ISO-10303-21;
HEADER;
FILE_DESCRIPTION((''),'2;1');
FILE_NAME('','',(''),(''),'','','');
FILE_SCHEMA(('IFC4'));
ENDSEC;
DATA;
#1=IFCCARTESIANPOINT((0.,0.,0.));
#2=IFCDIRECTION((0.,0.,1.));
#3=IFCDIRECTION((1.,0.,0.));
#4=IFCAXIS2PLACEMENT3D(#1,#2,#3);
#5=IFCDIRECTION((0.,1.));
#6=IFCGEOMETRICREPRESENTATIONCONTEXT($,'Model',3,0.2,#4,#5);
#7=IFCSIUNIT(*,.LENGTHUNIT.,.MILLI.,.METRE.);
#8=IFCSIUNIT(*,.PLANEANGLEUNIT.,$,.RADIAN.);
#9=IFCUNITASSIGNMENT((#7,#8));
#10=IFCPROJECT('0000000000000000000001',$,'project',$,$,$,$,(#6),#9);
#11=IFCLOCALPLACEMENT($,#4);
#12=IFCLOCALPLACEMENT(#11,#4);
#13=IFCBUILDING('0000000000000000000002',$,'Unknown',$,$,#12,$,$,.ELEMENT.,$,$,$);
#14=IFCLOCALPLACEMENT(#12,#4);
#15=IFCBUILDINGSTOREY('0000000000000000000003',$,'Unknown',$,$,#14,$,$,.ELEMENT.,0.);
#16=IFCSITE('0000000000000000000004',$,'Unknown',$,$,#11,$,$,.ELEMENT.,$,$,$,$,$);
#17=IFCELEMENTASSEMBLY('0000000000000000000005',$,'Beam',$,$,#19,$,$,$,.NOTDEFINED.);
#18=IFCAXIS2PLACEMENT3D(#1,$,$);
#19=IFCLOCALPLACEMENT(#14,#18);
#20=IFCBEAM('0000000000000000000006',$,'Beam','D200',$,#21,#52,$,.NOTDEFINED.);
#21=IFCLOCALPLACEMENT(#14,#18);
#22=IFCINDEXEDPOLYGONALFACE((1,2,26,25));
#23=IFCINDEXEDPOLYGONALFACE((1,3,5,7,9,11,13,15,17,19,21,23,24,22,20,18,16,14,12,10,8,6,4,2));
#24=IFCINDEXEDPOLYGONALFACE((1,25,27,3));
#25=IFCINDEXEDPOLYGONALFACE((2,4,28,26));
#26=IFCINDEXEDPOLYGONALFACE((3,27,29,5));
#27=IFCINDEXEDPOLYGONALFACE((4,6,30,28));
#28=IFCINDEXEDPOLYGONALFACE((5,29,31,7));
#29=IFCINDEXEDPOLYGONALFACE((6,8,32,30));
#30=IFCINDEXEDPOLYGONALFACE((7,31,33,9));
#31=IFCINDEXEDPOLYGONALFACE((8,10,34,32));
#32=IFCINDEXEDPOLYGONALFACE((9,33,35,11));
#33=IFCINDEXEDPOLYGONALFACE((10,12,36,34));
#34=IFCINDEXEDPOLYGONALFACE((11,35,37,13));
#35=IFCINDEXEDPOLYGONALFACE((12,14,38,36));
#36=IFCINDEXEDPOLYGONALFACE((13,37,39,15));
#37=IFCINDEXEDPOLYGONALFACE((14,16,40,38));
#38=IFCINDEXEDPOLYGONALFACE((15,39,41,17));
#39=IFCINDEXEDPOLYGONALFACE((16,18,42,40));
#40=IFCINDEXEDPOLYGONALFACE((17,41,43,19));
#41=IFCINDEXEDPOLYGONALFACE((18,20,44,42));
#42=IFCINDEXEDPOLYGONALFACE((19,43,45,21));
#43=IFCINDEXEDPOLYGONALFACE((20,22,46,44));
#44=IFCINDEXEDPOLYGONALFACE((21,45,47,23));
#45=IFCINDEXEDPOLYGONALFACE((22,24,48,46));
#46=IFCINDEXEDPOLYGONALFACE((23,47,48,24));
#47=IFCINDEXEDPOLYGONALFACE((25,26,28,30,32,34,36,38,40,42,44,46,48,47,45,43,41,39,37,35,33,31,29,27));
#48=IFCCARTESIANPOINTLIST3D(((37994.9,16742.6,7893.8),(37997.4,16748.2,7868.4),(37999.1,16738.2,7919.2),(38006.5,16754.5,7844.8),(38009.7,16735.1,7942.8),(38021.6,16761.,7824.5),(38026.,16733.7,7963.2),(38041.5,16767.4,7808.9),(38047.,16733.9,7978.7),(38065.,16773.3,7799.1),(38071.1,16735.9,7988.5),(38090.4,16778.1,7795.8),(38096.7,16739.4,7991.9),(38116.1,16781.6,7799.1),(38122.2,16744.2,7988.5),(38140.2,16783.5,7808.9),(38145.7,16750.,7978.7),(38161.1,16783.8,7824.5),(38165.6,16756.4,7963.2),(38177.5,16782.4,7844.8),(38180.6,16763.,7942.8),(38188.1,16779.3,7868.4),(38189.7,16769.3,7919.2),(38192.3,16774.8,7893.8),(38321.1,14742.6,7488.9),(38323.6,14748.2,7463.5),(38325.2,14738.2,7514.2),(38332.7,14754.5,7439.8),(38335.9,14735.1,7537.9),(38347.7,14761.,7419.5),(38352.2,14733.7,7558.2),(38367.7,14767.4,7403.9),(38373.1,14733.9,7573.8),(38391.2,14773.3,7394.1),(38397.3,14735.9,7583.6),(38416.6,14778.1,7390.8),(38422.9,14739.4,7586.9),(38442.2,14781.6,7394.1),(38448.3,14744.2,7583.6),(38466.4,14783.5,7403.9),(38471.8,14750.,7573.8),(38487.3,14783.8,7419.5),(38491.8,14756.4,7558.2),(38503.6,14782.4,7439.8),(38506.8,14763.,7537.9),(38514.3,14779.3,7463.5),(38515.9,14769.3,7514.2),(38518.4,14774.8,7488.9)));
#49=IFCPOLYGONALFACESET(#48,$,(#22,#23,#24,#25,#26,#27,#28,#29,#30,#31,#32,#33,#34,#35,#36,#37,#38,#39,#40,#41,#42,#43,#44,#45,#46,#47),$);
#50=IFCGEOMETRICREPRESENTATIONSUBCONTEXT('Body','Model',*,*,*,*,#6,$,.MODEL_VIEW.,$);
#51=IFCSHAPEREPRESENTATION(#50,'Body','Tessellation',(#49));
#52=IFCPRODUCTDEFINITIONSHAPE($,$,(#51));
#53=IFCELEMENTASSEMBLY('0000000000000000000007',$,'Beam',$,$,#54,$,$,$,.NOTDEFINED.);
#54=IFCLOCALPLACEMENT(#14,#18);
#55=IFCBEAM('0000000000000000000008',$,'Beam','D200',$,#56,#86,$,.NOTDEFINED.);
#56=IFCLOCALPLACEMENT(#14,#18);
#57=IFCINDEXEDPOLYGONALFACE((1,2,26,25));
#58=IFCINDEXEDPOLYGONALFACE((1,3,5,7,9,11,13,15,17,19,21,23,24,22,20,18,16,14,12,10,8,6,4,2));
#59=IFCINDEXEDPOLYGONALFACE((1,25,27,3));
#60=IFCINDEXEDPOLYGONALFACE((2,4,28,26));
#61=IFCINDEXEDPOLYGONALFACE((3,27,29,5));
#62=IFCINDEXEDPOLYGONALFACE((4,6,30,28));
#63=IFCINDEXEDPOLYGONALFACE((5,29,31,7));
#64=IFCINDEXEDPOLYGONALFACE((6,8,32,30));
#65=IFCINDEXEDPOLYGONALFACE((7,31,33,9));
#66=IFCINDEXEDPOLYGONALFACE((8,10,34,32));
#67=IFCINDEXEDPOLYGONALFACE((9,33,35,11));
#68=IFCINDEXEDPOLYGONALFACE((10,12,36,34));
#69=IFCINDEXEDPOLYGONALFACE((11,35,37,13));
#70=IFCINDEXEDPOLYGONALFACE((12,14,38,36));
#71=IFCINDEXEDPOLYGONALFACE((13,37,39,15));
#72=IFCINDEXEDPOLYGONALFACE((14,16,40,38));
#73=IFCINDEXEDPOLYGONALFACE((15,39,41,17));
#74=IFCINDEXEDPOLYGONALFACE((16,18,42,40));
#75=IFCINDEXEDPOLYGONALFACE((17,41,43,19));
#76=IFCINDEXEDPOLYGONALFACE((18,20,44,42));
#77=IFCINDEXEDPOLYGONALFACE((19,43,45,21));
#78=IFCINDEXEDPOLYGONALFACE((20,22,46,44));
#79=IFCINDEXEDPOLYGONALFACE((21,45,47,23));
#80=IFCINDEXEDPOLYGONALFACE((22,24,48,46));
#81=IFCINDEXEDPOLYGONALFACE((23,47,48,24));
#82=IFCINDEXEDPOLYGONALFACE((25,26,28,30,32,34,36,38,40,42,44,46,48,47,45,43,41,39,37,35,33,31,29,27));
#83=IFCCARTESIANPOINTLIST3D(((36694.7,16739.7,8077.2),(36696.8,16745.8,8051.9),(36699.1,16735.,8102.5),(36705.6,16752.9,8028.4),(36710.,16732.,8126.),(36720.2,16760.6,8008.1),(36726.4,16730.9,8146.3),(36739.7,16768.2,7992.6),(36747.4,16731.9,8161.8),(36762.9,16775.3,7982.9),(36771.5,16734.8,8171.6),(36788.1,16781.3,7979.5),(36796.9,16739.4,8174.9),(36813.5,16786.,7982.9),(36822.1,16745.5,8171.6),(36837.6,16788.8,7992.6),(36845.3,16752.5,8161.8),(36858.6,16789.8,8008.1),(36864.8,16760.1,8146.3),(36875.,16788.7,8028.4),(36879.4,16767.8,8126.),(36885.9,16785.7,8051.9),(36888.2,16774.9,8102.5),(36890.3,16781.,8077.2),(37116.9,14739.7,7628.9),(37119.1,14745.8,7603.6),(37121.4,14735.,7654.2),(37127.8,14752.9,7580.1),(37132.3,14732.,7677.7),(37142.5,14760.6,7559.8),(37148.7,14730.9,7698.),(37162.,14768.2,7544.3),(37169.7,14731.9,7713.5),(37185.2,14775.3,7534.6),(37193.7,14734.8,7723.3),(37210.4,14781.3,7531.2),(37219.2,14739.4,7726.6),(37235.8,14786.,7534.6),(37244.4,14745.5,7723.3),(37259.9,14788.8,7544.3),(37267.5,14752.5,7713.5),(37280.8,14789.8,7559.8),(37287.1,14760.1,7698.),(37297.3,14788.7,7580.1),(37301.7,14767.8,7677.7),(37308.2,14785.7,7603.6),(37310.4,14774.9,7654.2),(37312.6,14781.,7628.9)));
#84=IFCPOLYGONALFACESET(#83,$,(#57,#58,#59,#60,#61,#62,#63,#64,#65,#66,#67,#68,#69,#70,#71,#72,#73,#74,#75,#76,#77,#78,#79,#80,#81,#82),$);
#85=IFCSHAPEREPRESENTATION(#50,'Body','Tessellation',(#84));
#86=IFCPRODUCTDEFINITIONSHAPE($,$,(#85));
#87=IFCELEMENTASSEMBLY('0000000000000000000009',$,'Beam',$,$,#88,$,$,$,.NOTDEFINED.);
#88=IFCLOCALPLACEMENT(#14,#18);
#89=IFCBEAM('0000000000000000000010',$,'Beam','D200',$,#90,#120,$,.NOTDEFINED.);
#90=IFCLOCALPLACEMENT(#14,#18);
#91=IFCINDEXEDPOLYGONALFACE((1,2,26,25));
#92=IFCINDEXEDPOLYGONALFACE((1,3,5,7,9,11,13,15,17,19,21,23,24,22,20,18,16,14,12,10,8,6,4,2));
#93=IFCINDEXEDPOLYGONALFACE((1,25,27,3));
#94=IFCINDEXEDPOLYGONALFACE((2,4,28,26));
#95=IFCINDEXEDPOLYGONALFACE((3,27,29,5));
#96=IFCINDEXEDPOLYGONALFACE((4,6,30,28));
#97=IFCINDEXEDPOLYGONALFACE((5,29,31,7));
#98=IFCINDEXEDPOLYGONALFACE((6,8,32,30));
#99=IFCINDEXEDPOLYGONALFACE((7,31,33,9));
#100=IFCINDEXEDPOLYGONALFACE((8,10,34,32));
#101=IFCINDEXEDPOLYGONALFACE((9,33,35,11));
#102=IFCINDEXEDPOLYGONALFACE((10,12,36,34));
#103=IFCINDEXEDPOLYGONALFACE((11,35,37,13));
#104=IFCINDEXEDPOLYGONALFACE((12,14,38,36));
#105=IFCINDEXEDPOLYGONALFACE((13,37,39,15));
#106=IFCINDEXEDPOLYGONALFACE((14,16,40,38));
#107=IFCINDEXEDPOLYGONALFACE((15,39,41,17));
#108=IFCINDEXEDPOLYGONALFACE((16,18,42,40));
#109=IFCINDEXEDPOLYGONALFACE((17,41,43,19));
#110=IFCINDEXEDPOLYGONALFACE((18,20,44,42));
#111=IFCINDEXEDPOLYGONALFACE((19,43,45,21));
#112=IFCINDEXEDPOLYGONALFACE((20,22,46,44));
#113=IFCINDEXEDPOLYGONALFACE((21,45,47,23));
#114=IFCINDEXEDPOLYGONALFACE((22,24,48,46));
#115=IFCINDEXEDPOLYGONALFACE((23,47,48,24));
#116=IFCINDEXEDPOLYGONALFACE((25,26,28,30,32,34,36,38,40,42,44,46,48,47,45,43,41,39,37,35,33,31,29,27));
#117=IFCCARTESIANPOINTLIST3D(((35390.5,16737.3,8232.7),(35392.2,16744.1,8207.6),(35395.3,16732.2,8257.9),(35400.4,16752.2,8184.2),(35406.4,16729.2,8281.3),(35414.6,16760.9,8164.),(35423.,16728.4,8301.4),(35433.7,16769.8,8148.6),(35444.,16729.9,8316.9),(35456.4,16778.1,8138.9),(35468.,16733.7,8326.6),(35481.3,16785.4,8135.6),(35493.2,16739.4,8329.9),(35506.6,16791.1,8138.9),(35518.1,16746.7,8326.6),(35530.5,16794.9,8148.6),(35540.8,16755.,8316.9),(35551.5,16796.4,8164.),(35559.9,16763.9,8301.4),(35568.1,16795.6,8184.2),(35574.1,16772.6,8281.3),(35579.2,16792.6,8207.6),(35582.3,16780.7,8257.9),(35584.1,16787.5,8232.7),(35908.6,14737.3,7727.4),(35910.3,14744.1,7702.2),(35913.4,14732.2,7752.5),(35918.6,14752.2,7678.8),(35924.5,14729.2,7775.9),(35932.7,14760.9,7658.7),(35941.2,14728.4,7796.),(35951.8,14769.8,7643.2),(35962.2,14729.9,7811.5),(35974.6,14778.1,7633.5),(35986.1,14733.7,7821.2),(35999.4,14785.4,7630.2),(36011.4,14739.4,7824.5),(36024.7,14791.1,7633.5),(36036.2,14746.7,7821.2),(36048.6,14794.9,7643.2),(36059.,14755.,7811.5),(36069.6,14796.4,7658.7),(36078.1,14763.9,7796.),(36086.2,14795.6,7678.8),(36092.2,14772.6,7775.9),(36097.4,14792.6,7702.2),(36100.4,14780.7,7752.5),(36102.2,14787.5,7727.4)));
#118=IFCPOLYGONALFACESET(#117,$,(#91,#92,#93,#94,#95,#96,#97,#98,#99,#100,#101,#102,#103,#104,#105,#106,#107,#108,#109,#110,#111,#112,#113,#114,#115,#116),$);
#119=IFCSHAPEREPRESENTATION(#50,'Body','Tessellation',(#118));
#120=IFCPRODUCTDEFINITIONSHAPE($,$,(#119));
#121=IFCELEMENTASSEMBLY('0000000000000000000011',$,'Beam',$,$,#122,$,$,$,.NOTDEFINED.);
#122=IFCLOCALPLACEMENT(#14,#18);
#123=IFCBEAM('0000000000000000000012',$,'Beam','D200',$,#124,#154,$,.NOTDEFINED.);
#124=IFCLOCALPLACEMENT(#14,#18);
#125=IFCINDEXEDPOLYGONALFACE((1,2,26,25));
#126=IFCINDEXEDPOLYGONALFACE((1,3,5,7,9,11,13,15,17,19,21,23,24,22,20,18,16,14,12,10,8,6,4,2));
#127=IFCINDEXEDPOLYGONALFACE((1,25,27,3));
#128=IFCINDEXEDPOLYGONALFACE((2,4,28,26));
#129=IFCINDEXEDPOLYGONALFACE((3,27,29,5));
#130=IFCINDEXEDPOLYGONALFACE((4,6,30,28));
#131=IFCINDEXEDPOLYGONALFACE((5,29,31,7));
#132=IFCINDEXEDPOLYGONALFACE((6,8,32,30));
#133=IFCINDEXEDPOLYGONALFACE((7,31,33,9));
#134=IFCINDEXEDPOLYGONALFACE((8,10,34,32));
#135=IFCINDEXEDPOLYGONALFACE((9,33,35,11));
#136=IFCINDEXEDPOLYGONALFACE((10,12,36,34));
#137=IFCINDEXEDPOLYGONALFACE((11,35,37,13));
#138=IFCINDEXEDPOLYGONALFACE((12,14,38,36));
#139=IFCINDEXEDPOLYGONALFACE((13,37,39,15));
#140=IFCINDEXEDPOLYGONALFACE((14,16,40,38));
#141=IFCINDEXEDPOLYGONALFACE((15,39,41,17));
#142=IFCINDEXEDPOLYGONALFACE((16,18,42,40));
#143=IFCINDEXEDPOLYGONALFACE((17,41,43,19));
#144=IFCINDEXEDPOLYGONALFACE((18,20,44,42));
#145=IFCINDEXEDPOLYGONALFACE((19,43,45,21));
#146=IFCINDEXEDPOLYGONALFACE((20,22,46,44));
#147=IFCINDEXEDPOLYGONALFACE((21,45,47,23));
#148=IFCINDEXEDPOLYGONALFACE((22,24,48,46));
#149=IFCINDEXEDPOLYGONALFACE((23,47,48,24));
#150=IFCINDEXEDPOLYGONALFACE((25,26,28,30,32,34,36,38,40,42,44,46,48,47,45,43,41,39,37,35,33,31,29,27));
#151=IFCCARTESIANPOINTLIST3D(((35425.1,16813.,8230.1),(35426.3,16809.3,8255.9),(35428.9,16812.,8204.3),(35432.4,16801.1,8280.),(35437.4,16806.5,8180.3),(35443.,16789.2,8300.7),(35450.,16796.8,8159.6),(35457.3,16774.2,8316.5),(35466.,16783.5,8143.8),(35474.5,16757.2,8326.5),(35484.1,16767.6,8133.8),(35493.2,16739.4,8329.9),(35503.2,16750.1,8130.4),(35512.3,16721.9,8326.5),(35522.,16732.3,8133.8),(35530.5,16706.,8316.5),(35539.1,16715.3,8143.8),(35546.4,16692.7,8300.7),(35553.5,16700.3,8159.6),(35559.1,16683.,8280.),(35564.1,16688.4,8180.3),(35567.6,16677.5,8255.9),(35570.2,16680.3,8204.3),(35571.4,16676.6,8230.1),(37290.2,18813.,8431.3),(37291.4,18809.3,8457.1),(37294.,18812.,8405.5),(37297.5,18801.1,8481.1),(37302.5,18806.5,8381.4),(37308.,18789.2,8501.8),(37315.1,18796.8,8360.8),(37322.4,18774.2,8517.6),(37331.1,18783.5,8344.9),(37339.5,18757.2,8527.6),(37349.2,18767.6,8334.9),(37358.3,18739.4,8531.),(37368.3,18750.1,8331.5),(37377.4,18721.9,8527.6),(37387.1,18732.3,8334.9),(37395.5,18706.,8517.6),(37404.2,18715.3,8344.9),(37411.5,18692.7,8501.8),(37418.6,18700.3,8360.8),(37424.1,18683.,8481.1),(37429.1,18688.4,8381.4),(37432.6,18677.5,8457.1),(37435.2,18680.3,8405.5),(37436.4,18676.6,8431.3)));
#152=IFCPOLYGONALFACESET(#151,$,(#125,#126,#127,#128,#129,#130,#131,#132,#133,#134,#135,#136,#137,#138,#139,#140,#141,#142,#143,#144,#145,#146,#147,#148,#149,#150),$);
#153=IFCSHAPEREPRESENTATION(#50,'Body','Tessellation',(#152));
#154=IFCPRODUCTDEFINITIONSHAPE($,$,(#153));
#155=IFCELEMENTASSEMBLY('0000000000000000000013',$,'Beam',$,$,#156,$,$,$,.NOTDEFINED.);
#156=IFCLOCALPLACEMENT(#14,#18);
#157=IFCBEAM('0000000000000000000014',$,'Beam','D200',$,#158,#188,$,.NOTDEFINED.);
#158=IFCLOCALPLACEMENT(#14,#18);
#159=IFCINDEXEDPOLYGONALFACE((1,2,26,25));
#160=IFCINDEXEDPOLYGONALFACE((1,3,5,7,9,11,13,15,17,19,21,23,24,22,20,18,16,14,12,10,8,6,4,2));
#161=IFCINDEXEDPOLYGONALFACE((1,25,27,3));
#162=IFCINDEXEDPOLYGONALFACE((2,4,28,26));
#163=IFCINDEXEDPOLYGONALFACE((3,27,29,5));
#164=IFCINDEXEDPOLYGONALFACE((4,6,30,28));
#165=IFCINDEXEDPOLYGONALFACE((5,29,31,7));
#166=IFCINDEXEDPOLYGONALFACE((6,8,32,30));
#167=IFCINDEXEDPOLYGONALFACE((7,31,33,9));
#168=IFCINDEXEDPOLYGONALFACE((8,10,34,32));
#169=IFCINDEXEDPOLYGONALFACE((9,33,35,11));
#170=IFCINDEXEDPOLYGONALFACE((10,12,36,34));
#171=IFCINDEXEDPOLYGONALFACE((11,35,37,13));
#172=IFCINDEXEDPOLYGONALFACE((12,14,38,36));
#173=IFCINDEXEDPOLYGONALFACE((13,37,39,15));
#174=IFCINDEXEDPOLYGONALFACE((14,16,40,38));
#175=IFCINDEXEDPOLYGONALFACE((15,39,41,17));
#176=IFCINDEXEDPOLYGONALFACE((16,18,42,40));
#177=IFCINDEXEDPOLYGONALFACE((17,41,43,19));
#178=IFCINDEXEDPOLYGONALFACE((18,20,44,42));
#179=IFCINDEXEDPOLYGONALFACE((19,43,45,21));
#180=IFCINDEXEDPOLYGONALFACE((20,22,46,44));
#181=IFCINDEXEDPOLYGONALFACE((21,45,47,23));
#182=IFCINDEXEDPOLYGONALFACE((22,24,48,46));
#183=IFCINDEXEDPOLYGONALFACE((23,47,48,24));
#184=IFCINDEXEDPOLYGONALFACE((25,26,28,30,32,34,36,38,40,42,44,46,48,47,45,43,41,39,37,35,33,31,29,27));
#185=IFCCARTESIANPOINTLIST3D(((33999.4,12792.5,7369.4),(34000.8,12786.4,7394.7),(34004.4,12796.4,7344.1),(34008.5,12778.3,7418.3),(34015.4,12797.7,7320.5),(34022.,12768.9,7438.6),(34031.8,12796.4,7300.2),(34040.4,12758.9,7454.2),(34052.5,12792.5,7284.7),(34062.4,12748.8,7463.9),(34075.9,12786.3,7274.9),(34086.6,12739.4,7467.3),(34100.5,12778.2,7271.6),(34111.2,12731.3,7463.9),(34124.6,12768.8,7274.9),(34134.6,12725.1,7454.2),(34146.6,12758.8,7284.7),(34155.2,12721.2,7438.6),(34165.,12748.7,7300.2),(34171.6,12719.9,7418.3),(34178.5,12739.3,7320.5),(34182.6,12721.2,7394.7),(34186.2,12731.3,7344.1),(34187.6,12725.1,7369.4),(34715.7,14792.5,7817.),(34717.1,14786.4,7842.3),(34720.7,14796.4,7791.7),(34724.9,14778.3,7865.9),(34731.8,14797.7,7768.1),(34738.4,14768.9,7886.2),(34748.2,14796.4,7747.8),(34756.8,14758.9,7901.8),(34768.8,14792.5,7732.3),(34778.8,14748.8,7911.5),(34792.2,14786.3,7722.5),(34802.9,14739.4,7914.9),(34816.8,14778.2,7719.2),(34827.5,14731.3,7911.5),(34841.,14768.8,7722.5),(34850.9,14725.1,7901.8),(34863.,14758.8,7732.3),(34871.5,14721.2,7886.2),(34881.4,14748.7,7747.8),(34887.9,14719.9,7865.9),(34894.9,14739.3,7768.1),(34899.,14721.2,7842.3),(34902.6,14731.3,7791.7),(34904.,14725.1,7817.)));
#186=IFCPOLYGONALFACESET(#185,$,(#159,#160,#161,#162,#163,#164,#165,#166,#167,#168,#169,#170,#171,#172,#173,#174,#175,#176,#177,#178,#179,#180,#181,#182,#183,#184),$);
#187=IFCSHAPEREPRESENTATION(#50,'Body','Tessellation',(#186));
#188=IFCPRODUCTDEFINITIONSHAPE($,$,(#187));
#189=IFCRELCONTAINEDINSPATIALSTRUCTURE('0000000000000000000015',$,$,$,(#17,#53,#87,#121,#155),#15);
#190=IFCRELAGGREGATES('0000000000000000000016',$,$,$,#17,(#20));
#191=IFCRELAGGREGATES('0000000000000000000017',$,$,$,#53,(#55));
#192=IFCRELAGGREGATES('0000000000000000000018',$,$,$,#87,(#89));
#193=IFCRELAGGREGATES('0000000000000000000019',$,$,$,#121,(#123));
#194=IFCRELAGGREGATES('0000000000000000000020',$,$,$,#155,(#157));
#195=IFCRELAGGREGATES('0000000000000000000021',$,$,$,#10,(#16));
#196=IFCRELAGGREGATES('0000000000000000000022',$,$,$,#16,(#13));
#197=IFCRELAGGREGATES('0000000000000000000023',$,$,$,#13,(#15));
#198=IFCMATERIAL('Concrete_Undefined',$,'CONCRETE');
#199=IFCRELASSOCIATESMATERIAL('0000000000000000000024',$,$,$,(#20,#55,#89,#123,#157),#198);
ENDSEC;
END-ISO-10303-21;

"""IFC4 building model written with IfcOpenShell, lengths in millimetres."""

from ifc_helpers import new_model, si_unit, direction, frame, origin_with_axes, place, context, subcontext, project, spatial, line, indexed_curve, outline, extrude, material, element, aggregate, save


model = new_model("IFC4")

# Units and contexts
model_context = context("Model", 3, precision=0.2, world=origin_with_axes(), true_north=direction((0.0, 1.0)))
body_context = subcontext(model_context, "Body", "Model", "MODEL_VIEW")
ifc_project = project(units=[si_unit("LENGTHUNIT", "METRE", prefix="MILLI"), si_unit("PLANEANGLEUNIT", "RADIAN")], contexts=[model_context])

# Site, building, storey
site_placement = place(None, origin_with_axes())
site = spatial("IfcSite", under=ifc_project, at=site_placement, Name="Unknown", CompositionType="ELEMENT")
building_placement = place(site_placement, origin_with_axes())
building = spatial("IfcBuilding", under=site, at=building_placement, Name="Unknown", CompositionType="ELEMENT")
storey_placement = place(building_placement, origin_with_axes())
storey = spatial("IfcBuildingStorey", under=building, at=storey_placement, Name="Unknown", CompositionType="ELEMENT", Elevation=0.0)

# Element assemblies, beams
assembly_1_placement = place(storey_placement, frame((38093.6, 16758.7, 7893.8), z_axis=(-0.986961, -0.160962, 0.0), x_axis=(0.157841, -0.967824, -0.195966)))
assembly_1 = element("IfcElementAssembly", 1, at=assembly_1_placement, inside=storey, Name="Beam", PredefinedType="NOTDEFINED")
ifc_material = material(Name="Concrete_Undefined", Category="CONCRETE")
beam_1_placement = place(assembly_1_placement, origin_with_axes())
beam_1 = element("IfcBeam", 2, at=beam_1_placement, material=ifc_material, Name="Beam", Description="D200", PredefinedType="NOTDEFINED", context=body_context, shape_type="SolidModel", body=[
    extrude(outline(indexed_curve([(100.0, 0.0), (96.6, 25.9), (86.6, 50.0), (70.7, 70.7), (50.0, 86.6), (25.9, 96.6), (0.0, 100.0), (-25.9, 96.6), (-50.0, 86.6), (-70.7, 70.7), (-86.6, 50.0), (-96.6, 25.9), (-100.0, 0.0), (-96.6, -25.9), (-86.6, -50.0), (-70.7, -70.7), (-50.0, -86.6), (-25.9, -96.6), (0.0, -100.0), (25.9, -96.6), (50.0, -86.6), (70.7, -70.7), (86.6, -50.0), (96.6, -25.9)], segments=[line(1, 2, 3, 4, 5, 6, 7, 8, 9, 10, 11, 12, 13, 14, 15, 16, 17, 18, 19, 20, 21, 22, 23, 24, 1)])), frame((0.0, 0.0, 0.0), z_axis=(-1.0, 0.0, 0.0), x_axis=(0.0, 0.0, 1.0)), (0.0, 0.0, -1.0), 2066.5),
])
aggregate(assembly_1, [beam_1])
assembly_2_placement = place(storey_placement, frame((36792.5, 16760.4, 8077.2), z_axis=(-0.978427, -0.206591, 0.0), x_axis=(0.201794, -0.955712, -0.214226)))
assembly_2 = element("IfcElementAssembly", 3, at=assembly_2_placement, inside=storey, Name="Beam", PredefinedType="NOTDEFINED")
beam_2_placement = place(assembly_2_placement, origin_with_axes())
beam_2 = element("IfcBeam", 4, at=beam_2_placement, material=ifc_material, Name="Beam", Description="D200", PredefinedType="NOTDEFINED", context=body_context, shape_type="SolidModel", body=[
    extrude(outline(indexed_curve([(100.0, 0.0), (96.6, 25.9), (86.6, 50.0), (70.7, 70.7), (50.0, 86.6), (25.9, 96.6), (0.0, 100.0), (-25.9, 96.6), (-50.0, 86.6), (-70.7, 70.7), (-86.6, 50.0), (-96.6, 25.9), (-100.0, 0.0), (-96.6, -25.9), (-86.6, -50.0), (-70.7, -70.7), (-50.0, -86.6), (-25.9, -96.6), (0.0, -100.0), (25.9, -96.6), (50.0, -86.6), (70.7, -70.7), (86.6, -50.0), (96.6, -25.9)], segments=[line(1, 2, 3, 4, 5, 6, 7, 8, 9, 10, 11, 12, 13, 14, 15, 16, 17, 18, 19, 20, 21, 22, 23, 24, 1)])), frame((0.0, 0.0, 0.0), z_axis=(-1.0, 0.0, 0.0), x_axis=(0.0, 0.0, 1.0)), (0.0, 0.0, -1.0), 2092.7),
])
aggregate(assembly_2, [beam_2])
assembly_3_placement = place(storey_placement, frame((35487.3, 16762.4, 8232.7), z_axis=(-0.968042, -0.250789, 0.0), x_axis=(0.243607, -0.940319, -0.237604)))
assembly_3 = element("IfcElementAssembly", 5, at=assembly_3_placement, inside=storey, Name="Beam", PredefinedType="NOTDEFINED")
beam_3_placement = place(assembly_3_placement, origin_with_axes())
beam_3 = element("IfcBeam", 6, at=beam_3_placement, material=ifc_material, Name="Beam", Description="D200", PredefinedType="NOTDEFINED", context=body_context, shape_type="SolidModel", body=[
    extrude(outline(indexed_curve([(100.0, 0.0), (96.6, 25.9), (86.6, 50.0), (70.7, 70.7), (50.0, 86.6), (25.9, 96.6), (0.0, 100.0), (-25.9, 96.6), (-50.0, 86.6), (-70.7, 70.7), (-86.6, 50.0), (-96.6, 25.9), (-100.0, 0.0), (-96.6, -25.9), (-86.6, -50.0), (-70.7, -70.7), (-50.0, -86.6), (-25.9, -96.6), (0.0, -100.0), (25.9, -96.6), (50.0, -86.6), (70.7, -70.7), (86.6, -50.0), (96.6, -25.9)], segments=[line(1, 2, 3, 4, 5, 6, 7, 8, 9, 10, 11, 12, 13, 14, 15, 16, 17, 18, 19, 20, 21, 22, 23, 24, 1)])), frame((0.0, 0.0, 0.0), z_axis=(-1.0, 0.0, 0.0), x_axis=(0.0, 0.0, 1.0)), (0.0, 0.0, -1.0), 2126.9),
])
aggregate(assembly_3, [beam_3])
assembly_4_placement = place(storey_placement, frame((37363.3, 18744.8, 8431.3), z_axis=(-0.731344, 0.682008, 0.0), x_axis=(-0.680171, -0.729374, -0.073354)))
assembly_4 = element("IfcElementAssembly", 7, at=assembly_4_placement, inside=storey, Name="Beam", PredefinedType="NOTDEFINED")
beam_4_placement = place(assembly_4_placement, origin_with_axes())
beam_4 = element("IfcBeam", 8, at=beam_4_placement, material=ifc_material, Name="Beam", Description="D200", PredefinedType="NOTDEFINED", context=body_context, shape_type="SolidModel", body=[
    extrude(outline(indexed_curve([(100.0, 0.0), (96.6, 25.9), (86.6, 50.0), (70.7, 70.7), (50.0, 86.6), (25.9, 96.6), (0.0, 100.0), (-25.9, 96.6), (-50.0, 86.6), (-70.7, 70.7), (-86.6, 50.0), (-96.6, 25.9), (-100.0, 0.0), (-96.6, -25.9), (-86.6, -50.0), (-70.7, -70.7), (-50.0, -86.6), (-25.9, -96.6), (0.0, -100.0), (25.9, -96.6), (50.0, -86.6), (70.7, -70.7), (86.6, -50.0), (96.6, -25.9)], segments=[line(1, 2, 3, 4, 5, 6, 7, 8, 9, 10, 11, 12, 13, 14, 15, 16, 17, 18, 19, 20, 21, 22, 23, 24, 1)])), frame((0.0, 0.0, 0.0), z_axis=(-1.0, 0.0, 0.0), x_axis=(0.0, 0.0, 1.0)), (0.0, 0.0, -1.0), 2742.1),
])
aggregate(assembly_4, [beam_4])
assembly_5_placement = place(storey_placement, frame((34809.9, 14758.8, 7817.0), z_axis=(-0.94143, 0.33721, 0.0), x_axis=(-0.329966, -0.921206, -0.206161)))
assembly_5 = element("IfcElementAssembly", 9, at=assembly_5_placement, inside=storey, Name="Beam", PredefinedType="NOTDEFINED")
beam_5_placement = place(assembly_5_placement, origin_with_axes())
beam_5 = element("IfcBeam", 10, at=beam_5_placement, material=ifc_material, Name="Beam", Description="D200", PredefinedType="NOTDEFINED", context=body_context, shape_type="SolidModel", body=[
    extrude(outline(indexed_curve([(100.0, 0.0), (96.6, 25.9), (86.6, 50.0), (70.7, 70.7), (50.0, 86.6), (25.9, 96.6), (0.0, 100.0), (-25.9, 96.6), (-50.0, 86.6), (-70.7, 70.7), (-86.6, 50.0), (-96.6, 25.9), (-100.0, 0.0), (-96.6, -25.9), (-86.6, -50.0), (-70.7, -70.7), (-50.0, -86.6), (-25.9, -96.6), (0.0, -100.0), (25.9, -96.6), (50.0, -86.6), (70.7, -70.7), (86.6, -50.0), (96.6, -25.9)], segments=[line(1, 2, 3, 4, 5, 6, 7, 8, 9, 10, 11, 12, 13, 14, 15, 16, 17, 18, 19, 20, 21, 22, 23, 24, 1)])), frame((0.0, 0.0, 0.0), z_axis=(-1.0, 0.0, 0.0), x_axis=(0.0, 0.0, 1.0)), (0.0, 0.0, -1.0), 2171.1),
])
aggregate(assembly_5, [beam_5])

save(model, "model.ifc")
